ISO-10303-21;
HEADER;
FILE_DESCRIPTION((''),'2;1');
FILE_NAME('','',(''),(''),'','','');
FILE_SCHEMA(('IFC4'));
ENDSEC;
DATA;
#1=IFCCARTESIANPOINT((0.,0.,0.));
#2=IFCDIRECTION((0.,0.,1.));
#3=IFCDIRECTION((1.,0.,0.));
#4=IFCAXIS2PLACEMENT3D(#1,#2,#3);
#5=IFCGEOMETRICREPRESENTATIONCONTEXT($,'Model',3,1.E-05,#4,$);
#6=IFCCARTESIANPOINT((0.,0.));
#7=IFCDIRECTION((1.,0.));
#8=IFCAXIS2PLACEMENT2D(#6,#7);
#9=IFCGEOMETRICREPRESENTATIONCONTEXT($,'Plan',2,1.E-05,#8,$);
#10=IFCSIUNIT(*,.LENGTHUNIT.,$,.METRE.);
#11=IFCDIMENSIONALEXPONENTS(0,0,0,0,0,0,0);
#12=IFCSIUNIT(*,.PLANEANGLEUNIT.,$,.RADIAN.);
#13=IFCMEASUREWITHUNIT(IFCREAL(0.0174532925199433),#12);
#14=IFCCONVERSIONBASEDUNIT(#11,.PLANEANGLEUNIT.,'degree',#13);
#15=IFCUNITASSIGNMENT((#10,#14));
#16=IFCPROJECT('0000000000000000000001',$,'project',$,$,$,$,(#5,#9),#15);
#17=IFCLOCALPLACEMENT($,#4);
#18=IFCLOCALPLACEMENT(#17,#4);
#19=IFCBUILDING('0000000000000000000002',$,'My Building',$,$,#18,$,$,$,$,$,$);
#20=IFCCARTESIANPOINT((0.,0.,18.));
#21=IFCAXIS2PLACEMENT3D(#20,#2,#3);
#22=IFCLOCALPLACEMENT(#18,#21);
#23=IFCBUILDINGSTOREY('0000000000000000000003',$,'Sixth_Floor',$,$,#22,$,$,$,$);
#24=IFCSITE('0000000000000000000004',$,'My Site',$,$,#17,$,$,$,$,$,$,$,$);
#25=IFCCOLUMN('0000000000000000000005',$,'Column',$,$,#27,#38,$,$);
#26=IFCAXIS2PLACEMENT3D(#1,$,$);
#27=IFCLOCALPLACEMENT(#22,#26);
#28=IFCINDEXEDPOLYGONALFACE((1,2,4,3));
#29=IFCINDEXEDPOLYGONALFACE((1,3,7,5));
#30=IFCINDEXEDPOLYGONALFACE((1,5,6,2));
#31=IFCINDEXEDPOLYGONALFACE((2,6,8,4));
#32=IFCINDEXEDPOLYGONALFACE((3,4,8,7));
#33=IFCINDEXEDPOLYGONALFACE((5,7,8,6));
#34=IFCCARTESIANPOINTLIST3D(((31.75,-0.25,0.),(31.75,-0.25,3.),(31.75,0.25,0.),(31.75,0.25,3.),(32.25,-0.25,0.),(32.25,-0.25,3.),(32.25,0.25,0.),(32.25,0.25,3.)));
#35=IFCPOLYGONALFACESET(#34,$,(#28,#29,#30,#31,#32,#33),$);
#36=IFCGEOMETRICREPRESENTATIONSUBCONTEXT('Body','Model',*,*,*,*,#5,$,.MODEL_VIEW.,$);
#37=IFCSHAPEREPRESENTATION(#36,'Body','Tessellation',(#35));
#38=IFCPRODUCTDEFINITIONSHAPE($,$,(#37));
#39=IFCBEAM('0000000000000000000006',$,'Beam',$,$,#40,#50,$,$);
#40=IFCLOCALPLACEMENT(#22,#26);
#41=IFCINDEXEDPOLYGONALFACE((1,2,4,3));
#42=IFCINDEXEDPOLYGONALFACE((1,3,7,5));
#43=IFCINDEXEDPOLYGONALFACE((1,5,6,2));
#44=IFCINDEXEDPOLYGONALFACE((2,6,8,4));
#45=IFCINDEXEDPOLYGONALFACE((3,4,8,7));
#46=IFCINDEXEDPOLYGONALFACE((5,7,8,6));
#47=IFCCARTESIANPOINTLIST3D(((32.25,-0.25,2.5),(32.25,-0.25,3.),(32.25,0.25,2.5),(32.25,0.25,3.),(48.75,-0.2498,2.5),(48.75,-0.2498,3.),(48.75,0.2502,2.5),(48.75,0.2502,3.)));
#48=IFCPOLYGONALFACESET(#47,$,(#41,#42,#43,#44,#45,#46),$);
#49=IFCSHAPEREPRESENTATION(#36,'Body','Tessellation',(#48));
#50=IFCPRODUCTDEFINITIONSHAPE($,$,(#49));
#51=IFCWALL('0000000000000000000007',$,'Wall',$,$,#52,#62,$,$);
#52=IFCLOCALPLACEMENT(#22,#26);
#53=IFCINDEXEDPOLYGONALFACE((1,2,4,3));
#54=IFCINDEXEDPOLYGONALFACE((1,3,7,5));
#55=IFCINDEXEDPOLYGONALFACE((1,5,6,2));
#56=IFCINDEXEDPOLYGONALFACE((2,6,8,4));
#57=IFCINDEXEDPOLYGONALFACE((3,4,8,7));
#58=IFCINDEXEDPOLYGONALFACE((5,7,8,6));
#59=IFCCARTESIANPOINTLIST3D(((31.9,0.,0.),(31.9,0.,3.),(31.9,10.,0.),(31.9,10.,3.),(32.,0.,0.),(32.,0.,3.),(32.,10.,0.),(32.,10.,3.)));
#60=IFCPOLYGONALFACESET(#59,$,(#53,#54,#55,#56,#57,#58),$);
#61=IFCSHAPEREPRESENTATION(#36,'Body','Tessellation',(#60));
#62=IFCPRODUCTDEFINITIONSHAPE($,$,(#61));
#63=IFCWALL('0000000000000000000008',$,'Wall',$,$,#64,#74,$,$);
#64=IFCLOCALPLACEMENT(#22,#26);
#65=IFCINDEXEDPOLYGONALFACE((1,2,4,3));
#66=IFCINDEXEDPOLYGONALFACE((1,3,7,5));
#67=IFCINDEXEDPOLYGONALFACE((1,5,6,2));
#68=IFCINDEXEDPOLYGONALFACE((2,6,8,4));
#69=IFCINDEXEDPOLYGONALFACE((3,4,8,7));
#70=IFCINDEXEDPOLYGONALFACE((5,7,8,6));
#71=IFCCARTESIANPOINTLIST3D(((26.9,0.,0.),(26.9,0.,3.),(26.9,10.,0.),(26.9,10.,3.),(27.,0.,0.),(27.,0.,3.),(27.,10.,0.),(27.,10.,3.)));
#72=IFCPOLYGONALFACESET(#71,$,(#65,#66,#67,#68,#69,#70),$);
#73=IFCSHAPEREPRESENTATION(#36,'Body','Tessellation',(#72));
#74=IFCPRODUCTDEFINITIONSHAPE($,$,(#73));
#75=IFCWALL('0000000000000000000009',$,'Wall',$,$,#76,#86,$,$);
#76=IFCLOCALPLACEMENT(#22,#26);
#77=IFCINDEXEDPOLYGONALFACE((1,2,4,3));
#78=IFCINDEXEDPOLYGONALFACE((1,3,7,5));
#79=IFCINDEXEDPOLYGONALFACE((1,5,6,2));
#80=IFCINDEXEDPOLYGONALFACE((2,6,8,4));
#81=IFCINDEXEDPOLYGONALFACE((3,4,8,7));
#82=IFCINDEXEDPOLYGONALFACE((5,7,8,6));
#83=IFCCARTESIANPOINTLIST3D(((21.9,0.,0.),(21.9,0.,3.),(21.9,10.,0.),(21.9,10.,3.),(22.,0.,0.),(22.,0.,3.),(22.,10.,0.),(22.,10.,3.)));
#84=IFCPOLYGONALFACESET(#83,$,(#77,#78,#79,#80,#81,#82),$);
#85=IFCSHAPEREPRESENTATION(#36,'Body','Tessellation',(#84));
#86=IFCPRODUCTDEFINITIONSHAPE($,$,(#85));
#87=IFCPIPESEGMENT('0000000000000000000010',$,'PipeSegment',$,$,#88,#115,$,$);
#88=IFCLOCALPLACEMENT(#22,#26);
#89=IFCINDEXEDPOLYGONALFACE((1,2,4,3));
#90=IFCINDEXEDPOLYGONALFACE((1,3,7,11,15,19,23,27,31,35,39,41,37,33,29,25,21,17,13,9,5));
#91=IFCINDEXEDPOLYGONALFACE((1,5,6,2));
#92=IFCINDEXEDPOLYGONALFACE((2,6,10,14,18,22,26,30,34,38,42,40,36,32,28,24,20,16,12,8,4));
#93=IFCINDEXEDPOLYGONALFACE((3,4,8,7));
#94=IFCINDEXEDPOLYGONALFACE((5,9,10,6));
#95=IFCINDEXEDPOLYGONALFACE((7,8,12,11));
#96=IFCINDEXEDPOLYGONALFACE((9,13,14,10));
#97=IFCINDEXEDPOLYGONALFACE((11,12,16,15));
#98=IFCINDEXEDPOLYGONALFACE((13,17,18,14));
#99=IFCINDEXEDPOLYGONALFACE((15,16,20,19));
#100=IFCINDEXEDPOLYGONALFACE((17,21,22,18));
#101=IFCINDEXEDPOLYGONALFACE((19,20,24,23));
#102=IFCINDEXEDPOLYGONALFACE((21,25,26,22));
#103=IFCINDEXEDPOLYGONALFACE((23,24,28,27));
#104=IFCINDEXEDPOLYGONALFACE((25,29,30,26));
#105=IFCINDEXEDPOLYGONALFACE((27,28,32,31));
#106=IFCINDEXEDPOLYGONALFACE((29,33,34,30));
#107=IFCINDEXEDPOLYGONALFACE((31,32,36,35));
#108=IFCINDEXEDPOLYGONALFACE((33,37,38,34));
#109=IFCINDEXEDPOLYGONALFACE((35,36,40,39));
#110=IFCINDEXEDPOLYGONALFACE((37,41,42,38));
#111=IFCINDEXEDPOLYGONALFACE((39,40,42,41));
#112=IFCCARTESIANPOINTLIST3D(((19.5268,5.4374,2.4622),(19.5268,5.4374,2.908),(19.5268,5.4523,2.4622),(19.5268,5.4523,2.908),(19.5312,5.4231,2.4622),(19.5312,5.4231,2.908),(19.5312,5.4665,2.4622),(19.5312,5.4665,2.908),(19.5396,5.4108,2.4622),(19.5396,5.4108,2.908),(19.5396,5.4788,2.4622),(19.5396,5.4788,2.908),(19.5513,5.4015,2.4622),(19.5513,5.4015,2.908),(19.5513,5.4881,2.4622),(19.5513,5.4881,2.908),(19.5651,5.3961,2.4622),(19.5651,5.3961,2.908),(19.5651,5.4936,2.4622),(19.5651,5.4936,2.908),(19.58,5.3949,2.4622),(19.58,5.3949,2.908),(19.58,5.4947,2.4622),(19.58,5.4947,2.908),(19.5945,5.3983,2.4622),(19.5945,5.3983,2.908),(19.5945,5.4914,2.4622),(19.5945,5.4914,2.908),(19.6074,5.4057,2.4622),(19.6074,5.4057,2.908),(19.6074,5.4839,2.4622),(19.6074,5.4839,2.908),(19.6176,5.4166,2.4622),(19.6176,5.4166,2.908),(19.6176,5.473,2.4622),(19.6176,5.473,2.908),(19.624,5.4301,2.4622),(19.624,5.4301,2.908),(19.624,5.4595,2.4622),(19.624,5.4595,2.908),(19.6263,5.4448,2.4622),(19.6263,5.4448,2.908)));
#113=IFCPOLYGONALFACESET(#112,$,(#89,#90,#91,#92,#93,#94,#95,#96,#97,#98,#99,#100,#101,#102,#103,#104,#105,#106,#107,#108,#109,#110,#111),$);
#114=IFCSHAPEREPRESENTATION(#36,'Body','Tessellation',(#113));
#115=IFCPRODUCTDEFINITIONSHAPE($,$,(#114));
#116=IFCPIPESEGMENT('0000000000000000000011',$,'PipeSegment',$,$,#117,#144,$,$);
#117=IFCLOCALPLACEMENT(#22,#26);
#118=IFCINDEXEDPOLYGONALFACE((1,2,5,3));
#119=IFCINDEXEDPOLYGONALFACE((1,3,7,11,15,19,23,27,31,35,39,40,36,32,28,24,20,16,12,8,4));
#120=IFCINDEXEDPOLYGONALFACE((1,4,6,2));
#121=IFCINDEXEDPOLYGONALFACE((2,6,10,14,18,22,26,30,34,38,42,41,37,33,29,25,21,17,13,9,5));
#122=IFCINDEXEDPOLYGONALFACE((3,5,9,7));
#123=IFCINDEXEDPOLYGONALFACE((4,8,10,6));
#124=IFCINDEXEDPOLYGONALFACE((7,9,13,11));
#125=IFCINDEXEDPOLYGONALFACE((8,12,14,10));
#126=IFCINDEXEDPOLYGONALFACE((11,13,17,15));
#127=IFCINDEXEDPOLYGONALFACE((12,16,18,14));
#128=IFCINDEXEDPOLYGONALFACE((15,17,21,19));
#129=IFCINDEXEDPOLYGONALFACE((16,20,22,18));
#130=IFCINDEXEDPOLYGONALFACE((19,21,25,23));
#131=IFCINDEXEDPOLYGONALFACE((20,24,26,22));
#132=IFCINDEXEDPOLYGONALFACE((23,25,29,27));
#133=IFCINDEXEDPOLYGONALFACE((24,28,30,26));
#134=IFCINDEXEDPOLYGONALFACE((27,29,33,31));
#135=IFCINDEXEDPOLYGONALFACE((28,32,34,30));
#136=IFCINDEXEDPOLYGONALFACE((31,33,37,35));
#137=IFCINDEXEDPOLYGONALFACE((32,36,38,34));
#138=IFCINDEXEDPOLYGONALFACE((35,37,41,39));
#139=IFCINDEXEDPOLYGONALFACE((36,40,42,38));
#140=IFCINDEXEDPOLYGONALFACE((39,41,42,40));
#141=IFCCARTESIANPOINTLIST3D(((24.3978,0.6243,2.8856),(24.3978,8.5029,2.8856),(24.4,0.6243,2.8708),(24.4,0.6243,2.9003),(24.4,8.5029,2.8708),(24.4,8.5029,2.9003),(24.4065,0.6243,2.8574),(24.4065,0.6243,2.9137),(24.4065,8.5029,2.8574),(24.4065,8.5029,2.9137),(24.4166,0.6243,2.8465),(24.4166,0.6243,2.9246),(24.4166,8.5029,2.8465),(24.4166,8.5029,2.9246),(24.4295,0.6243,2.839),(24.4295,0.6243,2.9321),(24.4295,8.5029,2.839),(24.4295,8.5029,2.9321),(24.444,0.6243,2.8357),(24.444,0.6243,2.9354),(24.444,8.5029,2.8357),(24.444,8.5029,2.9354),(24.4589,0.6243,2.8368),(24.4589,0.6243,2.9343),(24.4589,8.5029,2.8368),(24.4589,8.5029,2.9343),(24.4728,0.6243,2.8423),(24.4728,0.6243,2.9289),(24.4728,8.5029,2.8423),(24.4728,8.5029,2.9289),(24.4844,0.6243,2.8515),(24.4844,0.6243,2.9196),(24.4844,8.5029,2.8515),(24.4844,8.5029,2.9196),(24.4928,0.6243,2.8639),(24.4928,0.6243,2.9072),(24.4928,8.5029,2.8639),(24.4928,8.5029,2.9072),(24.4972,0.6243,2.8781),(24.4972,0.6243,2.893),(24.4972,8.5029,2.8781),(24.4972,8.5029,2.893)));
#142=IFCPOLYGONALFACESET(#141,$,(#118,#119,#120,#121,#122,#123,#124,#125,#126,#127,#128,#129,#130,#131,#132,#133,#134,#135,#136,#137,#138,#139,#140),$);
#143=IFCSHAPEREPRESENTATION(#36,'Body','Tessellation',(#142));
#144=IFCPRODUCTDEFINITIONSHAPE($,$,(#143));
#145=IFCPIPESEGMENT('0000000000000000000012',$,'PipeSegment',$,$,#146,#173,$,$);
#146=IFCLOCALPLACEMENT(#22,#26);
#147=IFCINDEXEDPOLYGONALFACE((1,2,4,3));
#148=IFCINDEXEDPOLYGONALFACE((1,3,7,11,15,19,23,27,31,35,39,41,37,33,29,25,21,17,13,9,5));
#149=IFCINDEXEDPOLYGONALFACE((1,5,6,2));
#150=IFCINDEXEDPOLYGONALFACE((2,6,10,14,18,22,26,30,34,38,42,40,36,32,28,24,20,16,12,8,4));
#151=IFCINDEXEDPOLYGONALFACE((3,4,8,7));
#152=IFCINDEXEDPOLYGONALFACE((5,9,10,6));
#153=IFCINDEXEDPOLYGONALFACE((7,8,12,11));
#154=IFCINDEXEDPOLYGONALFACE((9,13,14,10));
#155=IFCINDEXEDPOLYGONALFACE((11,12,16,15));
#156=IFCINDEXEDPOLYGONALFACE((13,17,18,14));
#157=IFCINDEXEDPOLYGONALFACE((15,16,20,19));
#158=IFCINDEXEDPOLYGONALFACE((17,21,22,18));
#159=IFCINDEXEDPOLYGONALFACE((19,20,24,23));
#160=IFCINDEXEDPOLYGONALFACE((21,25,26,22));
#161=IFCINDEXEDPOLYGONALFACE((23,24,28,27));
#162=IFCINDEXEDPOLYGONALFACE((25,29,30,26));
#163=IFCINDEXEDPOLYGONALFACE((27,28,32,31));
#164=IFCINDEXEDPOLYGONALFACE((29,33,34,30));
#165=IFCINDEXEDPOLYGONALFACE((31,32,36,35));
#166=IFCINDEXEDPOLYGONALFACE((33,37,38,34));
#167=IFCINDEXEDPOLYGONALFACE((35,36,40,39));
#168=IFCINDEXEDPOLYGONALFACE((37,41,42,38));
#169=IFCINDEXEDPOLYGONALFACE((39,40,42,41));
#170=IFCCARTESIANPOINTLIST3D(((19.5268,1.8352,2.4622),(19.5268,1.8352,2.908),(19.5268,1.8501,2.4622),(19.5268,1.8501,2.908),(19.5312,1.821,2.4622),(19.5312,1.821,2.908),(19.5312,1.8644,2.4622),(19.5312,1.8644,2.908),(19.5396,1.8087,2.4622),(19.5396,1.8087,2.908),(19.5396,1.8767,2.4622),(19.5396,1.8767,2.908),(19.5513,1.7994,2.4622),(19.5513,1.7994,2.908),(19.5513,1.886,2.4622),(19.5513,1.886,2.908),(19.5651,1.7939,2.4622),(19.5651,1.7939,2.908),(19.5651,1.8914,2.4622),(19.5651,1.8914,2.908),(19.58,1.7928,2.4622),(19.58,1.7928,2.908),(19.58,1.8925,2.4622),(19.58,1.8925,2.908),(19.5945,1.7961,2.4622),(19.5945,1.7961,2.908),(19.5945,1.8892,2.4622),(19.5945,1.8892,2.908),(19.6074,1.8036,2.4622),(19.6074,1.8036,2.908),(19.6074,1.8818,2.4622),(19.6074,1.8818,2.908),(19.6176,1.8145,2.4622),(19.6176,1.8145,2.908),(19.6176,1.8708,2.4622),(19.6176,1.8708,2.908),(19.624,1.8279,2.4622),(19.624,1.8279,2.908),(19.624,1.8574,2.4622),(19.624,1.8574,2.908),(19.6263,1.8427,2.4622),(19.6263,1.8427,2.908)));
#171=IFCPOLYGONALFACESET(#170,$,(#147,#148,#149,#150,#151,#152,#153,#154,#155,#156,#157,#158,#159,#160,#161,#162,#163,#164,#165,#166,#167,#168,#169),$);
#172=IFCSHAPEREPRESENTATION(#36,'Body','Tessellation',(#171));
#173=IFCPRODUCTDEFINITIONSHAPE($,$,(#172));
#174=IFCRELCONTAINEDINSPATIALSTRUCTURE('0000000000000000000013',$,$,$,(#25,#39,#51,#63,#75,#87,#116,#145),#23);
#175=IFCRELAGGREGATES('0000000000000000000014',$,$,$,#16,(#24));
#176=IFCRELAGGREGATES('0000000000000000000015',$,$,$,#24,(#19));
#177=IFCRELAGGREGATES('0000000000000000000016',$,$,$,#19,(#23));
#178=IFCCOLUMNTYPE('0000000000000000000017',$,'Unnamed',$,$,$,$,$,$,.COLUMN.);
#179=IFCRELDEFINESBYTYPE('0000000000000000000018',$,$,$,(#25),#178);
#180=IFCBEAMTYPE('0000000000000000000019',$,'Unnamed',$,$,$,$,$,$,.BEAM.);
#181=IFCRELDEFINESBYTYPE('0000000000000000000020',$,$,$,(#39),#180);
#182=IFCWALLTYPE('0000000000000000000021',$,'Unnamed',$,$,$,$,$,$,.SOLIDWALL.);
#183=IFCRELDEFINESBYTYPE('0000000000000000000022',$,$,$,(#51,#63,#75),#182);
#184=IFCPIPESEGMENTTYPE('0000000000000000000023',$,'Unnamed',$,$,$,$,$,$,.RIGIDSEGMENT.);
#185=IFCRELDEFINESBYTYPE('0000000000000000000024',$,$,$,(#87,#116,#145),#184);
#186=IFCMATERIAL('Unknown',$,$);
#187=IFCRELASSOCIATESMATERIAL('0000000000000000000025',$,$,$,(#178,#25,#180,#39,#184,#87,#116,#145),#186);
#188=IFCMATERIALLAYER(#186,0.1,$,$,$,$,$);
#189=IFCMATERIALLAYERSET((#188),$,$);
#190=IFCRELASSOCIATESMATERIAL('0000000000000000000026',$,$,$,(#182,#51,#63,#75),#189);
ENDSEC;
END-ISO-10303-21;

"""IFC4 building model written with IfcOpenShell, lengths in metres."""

from ifc_helpers import new_model, entity, si_unit, converted_unit, frame, origin_with_axes, origin_2d_with_axis, place, context, subcontext, project, spatial, line, indexed_curve, rectangle, circle, outline, extrude, material, layer, layer_set, layer_usage, material_profile, profile_set, profile_usage, type_object, element, save


model = new_model("IFC4")

# Units and contexts
model_context = context("Model", 3, precision=1e-05, world=origin_with_axes())
plan_context = context("Plan", 2, precision=1e-05, world=origin_2d_with_axis())
body_context = subcontext(model_context, "Body", "Model", "MODEL_VIEW")
ifc_project = project(units=[si_unit("LENGTHUNIT", "METRE"), converted_unit("PLANEANGLEUNIT", "degree", entity("IfcReal", 0.0174532925199433), si_unit("PLANEANGLEUNIT", "RADIAN"), dimensions=[0, 0, 0, 0, 0, 0, 0])], contexts=[model_context, plan_context])

# Site, building, storey
site_placement = place(None, origin_with_axes())
site = spatial("IfcSite", under=ifc_project, at=site_placement, Name="My Site")
building_placement = place(site_placement, origin_with_axes())
building = spatial("IfcBuilding", under=site, at=building_placement, Name="My Building")
storey_placement = place(building_placement, frame((0.0, 0.0, 18.0), z_axis=(0.0, 0.0, 1.0), x_axis=(1.0, 0.0, 0.0)))
storey = spatial("IfcBuildingStorey", under=building, at=storey_placement, Name="Sixth_Floor")

# Column
ifc_material = material(Name="Unknown")
ifc_material_profile_1 = material_profile(ifc_material, rectangle(XDim=0.5, YDim=0.5))
ifc_profile_set_1 = profile_set([ifc_material_profile_1])
ifc_profile_usage_1 = profile_usage(ifc_profile_set_1, cardinal=5)
column_type = type_object("IfcColumnType", Name="Unnamed", PredefinedType="COLUMN", material=ifc_profile_set_1)
column_placement = place(storey_placement, frame((32.0, 0.0, 0.0), z_axis=(0.0, 0.0, 1.0), x_axis=(1.0, 0.0, 0.0)))
element("IfcColumn", 1, at=column_placement, inside=storey, type_object=column_type, material=ifc_profile_usage_1, Name="Column", context=body_context, shape_type="SweptSolid", body=[
    extrude(rectangle(XDim=0.5, YDim=0.5), origin_with_axes(), (0.0, 0.0, 1.0), 3.0),
])

# Beam
ifc_material_profile_2 = material_profile(ifc_material, rectangle(XDim=0.5, YDim=0.5))
ifc_profile_set_2 = profile_set([ifc_material_profile_2])
ifc_profile_usage_2 = profile_usage(ifc_profile_set_2, cardinal=6)
beam_type = type_object("IfcBeamType", Name="Unnamed", PredefinedType="BEAM", material=ifc_profile_set_2)
beam_placement = place(storey_placement, frame((32.25, -0.25, 2.75), z_axis=(1.0, 0.000012, 0.0), x_axis=(-0.000012, 1.0, 0.0)))
element("IfcBeam", 2, at=beam_placement, inside=storey, type_object=beam_type, material=ifc_profile_usage_2, Name="Beam", context=body_context, shape_type="SweptSolid", body=[
    extrude(rectangle(XDim=0.5, YDim=0.5), frame((0.25, 0.0, 0.0), z_axis=(0.0, 0.0, 1.0), x_axis=(1.0, 0.0, 0.0)), (0.0, 0.0, 1.0), 16.5),
])

# Walls
ifc_layer = layer(ifc_material, 0.1)
ifc_layer_set = layer_set([ifc_layer])
ifc_layer_usage_1 = layer_usage(ifc_layer_set, "AXIS2", "POSITIVE", 0.0)
wall_type = type_object("IfcWallType", Name="Unnamed", PredefinedType="SOLIDWALL", material=ifc_layer_set)
wall_1_placement = place(storey_placement, frame((31.9, 10.0, 0.0), z_axis=(0.0, 0.0, 1.0), x_axis=(0.0, -1.0, 0.0)))
element("IfcWall", 3, at=wall_1_placement, inside=storey, type_object=wall_type, material=ifc_layer_usage_1, Name="Wall", context=body_context, shape_type="SweptSolid", body=[
    extrude(outline(indexed_curve([(0.0, 0.0), (0.0, 0.1), (10.0, 0.1), (10.0, 0.0)], segments=[line(1, 2, 3, 4, 1)])), origin_with_axes(), (0.0, 0.0, 1.0), 3.0),
])
ifc_layer_usage_2 = layer_usage(ifc_layer_set, "AXIS2", "POSITIVE", 0.0)
wall_2_placement = place(storey_placement, frame((26.9, 10.0, 0.0), z_axis=(0.0, 0.0, 1.0), x_axis=(0.0, -1.0, 0.0)))
element("IfcWall", 4, at=wall_2_placement, inside=storey, type_object=wall_type, material=ifc_layer_usage_2, Name="Wall", context=body_context, shape_type="SweptSolid", body=[
    extrude(outline(indexed_curve([(0.0, 0.0), (0.0, 0.1), (10.0, 0.1), (10.0, 0.0)], segments=[line(1, 2, 3, 4, 1)])), origin_with_axes(), (0.0, 0.0, 1.0), 3.0),
])
ifc_layer_usage_3 = layer_usage(ifc_layer_set, "AXIS2", "POSITIVE", 0.0)
wall_3_placement = place(storey_placement, frame((21.9, 10.0, 0.0), z_axis=(0.0, 0.0, 1.0), x_axis=(0.0, -1.0, 0.0)))
element("IfcWall", 5, at=wall_3_placement, inside=storey, type_object=wall_type, material=ifc_layer_usage_3, Name="Wall", context=body_context, shape_type="SweptSolid", body=[
    extrude(outline(indexed_curve([(0.0, 0.0), (0.0, 0.1), (10.0, 0.1), (10.0, 0.0)], segments=[line(1, 2, 3, 4, 1)])), origin_with_axes(), (0.0, 0.0, 1.0), 3.0),
])

# Pipe segments
ifc_material_profile_3 = material_profile(ifc_material, circle(Radius=0.05))
ifc_profile_set_3 = profile_set([ifc_material_profile_3])
ifc_profile_usage_3 = profile_usage(ifc_profile_set_3, cardinal=5)
pipe_segment_type = type_object("IfcPipeSegmentType", Name="Unnamed", PredefinedType="RIGIDSEGMENT", material=ifc_profile_set_3)
pipe_segment_1_placement = place(storey_placement, frame((19.5763, 5.4448, 2.908), z_axis=(0.0, 0.0, -1.0), x_axis=(1.0, 0.0, 0.0)))
element("IfcPipeSegment", 6, at=pipe_segment_1_placement, inside=storey, type_object=pipe_segment_type, material=ifc_profile_usage_3, Name="PipeSegment", context=body_context, shape_type="SweptSolid", body=[
    extrude(circle(Radius=0.05), origin_with_axes(), (0.0, 0.0, 1.0), 0.4458),
])
ifc_profile_usage_4 = profile_usage(ifc_profile_set_3, cardinal=5)
pipe_segment_2_placement = place(storey_placement, frame((24.4478, 0.6243, 2.8856), z_axis=(0.0, 1.0, 0.0), x_axis=(-1.0, 0.0, 0.0)))
element("IfcPipeSegment", 7, at=pipe_segment_2_placement, inside=storey, type_object=pipe_segment_type, material=ifc_profile_usage_4, Name="PipeSegment", context=body_context, shape_type="SweptSolid", body=[
    extrude(circle(Radius=0.05), origin_with_axes(), (0.0, 0.0, 1.0), 7.8786),
])
ifc_profile_usage_5 = profile_usage(ifc_profile_set_3, cardinal=5)
pipe_segment_3_placement = place(storey_placement, frame((19.5763, 1.8427, 2.908), z_axis=(0.0, 0.0, -1.0), x_axis=(1.0, 0.0, 0.0)))
element("IfcPipeSegment", 8, at=pipe_segment_3_placement, inside=storey, type_object=pipe_segment_type, material=ifc_profile_usage_5, Name="PipeSegment", context=body_context, shape_type="SweptSolid", body=[
    extrude(circle(Radius=0.05), origin_with_axes(), (0.0, 0.0, 1.0), 0.4458),
])

save(model, "model.ifc")
